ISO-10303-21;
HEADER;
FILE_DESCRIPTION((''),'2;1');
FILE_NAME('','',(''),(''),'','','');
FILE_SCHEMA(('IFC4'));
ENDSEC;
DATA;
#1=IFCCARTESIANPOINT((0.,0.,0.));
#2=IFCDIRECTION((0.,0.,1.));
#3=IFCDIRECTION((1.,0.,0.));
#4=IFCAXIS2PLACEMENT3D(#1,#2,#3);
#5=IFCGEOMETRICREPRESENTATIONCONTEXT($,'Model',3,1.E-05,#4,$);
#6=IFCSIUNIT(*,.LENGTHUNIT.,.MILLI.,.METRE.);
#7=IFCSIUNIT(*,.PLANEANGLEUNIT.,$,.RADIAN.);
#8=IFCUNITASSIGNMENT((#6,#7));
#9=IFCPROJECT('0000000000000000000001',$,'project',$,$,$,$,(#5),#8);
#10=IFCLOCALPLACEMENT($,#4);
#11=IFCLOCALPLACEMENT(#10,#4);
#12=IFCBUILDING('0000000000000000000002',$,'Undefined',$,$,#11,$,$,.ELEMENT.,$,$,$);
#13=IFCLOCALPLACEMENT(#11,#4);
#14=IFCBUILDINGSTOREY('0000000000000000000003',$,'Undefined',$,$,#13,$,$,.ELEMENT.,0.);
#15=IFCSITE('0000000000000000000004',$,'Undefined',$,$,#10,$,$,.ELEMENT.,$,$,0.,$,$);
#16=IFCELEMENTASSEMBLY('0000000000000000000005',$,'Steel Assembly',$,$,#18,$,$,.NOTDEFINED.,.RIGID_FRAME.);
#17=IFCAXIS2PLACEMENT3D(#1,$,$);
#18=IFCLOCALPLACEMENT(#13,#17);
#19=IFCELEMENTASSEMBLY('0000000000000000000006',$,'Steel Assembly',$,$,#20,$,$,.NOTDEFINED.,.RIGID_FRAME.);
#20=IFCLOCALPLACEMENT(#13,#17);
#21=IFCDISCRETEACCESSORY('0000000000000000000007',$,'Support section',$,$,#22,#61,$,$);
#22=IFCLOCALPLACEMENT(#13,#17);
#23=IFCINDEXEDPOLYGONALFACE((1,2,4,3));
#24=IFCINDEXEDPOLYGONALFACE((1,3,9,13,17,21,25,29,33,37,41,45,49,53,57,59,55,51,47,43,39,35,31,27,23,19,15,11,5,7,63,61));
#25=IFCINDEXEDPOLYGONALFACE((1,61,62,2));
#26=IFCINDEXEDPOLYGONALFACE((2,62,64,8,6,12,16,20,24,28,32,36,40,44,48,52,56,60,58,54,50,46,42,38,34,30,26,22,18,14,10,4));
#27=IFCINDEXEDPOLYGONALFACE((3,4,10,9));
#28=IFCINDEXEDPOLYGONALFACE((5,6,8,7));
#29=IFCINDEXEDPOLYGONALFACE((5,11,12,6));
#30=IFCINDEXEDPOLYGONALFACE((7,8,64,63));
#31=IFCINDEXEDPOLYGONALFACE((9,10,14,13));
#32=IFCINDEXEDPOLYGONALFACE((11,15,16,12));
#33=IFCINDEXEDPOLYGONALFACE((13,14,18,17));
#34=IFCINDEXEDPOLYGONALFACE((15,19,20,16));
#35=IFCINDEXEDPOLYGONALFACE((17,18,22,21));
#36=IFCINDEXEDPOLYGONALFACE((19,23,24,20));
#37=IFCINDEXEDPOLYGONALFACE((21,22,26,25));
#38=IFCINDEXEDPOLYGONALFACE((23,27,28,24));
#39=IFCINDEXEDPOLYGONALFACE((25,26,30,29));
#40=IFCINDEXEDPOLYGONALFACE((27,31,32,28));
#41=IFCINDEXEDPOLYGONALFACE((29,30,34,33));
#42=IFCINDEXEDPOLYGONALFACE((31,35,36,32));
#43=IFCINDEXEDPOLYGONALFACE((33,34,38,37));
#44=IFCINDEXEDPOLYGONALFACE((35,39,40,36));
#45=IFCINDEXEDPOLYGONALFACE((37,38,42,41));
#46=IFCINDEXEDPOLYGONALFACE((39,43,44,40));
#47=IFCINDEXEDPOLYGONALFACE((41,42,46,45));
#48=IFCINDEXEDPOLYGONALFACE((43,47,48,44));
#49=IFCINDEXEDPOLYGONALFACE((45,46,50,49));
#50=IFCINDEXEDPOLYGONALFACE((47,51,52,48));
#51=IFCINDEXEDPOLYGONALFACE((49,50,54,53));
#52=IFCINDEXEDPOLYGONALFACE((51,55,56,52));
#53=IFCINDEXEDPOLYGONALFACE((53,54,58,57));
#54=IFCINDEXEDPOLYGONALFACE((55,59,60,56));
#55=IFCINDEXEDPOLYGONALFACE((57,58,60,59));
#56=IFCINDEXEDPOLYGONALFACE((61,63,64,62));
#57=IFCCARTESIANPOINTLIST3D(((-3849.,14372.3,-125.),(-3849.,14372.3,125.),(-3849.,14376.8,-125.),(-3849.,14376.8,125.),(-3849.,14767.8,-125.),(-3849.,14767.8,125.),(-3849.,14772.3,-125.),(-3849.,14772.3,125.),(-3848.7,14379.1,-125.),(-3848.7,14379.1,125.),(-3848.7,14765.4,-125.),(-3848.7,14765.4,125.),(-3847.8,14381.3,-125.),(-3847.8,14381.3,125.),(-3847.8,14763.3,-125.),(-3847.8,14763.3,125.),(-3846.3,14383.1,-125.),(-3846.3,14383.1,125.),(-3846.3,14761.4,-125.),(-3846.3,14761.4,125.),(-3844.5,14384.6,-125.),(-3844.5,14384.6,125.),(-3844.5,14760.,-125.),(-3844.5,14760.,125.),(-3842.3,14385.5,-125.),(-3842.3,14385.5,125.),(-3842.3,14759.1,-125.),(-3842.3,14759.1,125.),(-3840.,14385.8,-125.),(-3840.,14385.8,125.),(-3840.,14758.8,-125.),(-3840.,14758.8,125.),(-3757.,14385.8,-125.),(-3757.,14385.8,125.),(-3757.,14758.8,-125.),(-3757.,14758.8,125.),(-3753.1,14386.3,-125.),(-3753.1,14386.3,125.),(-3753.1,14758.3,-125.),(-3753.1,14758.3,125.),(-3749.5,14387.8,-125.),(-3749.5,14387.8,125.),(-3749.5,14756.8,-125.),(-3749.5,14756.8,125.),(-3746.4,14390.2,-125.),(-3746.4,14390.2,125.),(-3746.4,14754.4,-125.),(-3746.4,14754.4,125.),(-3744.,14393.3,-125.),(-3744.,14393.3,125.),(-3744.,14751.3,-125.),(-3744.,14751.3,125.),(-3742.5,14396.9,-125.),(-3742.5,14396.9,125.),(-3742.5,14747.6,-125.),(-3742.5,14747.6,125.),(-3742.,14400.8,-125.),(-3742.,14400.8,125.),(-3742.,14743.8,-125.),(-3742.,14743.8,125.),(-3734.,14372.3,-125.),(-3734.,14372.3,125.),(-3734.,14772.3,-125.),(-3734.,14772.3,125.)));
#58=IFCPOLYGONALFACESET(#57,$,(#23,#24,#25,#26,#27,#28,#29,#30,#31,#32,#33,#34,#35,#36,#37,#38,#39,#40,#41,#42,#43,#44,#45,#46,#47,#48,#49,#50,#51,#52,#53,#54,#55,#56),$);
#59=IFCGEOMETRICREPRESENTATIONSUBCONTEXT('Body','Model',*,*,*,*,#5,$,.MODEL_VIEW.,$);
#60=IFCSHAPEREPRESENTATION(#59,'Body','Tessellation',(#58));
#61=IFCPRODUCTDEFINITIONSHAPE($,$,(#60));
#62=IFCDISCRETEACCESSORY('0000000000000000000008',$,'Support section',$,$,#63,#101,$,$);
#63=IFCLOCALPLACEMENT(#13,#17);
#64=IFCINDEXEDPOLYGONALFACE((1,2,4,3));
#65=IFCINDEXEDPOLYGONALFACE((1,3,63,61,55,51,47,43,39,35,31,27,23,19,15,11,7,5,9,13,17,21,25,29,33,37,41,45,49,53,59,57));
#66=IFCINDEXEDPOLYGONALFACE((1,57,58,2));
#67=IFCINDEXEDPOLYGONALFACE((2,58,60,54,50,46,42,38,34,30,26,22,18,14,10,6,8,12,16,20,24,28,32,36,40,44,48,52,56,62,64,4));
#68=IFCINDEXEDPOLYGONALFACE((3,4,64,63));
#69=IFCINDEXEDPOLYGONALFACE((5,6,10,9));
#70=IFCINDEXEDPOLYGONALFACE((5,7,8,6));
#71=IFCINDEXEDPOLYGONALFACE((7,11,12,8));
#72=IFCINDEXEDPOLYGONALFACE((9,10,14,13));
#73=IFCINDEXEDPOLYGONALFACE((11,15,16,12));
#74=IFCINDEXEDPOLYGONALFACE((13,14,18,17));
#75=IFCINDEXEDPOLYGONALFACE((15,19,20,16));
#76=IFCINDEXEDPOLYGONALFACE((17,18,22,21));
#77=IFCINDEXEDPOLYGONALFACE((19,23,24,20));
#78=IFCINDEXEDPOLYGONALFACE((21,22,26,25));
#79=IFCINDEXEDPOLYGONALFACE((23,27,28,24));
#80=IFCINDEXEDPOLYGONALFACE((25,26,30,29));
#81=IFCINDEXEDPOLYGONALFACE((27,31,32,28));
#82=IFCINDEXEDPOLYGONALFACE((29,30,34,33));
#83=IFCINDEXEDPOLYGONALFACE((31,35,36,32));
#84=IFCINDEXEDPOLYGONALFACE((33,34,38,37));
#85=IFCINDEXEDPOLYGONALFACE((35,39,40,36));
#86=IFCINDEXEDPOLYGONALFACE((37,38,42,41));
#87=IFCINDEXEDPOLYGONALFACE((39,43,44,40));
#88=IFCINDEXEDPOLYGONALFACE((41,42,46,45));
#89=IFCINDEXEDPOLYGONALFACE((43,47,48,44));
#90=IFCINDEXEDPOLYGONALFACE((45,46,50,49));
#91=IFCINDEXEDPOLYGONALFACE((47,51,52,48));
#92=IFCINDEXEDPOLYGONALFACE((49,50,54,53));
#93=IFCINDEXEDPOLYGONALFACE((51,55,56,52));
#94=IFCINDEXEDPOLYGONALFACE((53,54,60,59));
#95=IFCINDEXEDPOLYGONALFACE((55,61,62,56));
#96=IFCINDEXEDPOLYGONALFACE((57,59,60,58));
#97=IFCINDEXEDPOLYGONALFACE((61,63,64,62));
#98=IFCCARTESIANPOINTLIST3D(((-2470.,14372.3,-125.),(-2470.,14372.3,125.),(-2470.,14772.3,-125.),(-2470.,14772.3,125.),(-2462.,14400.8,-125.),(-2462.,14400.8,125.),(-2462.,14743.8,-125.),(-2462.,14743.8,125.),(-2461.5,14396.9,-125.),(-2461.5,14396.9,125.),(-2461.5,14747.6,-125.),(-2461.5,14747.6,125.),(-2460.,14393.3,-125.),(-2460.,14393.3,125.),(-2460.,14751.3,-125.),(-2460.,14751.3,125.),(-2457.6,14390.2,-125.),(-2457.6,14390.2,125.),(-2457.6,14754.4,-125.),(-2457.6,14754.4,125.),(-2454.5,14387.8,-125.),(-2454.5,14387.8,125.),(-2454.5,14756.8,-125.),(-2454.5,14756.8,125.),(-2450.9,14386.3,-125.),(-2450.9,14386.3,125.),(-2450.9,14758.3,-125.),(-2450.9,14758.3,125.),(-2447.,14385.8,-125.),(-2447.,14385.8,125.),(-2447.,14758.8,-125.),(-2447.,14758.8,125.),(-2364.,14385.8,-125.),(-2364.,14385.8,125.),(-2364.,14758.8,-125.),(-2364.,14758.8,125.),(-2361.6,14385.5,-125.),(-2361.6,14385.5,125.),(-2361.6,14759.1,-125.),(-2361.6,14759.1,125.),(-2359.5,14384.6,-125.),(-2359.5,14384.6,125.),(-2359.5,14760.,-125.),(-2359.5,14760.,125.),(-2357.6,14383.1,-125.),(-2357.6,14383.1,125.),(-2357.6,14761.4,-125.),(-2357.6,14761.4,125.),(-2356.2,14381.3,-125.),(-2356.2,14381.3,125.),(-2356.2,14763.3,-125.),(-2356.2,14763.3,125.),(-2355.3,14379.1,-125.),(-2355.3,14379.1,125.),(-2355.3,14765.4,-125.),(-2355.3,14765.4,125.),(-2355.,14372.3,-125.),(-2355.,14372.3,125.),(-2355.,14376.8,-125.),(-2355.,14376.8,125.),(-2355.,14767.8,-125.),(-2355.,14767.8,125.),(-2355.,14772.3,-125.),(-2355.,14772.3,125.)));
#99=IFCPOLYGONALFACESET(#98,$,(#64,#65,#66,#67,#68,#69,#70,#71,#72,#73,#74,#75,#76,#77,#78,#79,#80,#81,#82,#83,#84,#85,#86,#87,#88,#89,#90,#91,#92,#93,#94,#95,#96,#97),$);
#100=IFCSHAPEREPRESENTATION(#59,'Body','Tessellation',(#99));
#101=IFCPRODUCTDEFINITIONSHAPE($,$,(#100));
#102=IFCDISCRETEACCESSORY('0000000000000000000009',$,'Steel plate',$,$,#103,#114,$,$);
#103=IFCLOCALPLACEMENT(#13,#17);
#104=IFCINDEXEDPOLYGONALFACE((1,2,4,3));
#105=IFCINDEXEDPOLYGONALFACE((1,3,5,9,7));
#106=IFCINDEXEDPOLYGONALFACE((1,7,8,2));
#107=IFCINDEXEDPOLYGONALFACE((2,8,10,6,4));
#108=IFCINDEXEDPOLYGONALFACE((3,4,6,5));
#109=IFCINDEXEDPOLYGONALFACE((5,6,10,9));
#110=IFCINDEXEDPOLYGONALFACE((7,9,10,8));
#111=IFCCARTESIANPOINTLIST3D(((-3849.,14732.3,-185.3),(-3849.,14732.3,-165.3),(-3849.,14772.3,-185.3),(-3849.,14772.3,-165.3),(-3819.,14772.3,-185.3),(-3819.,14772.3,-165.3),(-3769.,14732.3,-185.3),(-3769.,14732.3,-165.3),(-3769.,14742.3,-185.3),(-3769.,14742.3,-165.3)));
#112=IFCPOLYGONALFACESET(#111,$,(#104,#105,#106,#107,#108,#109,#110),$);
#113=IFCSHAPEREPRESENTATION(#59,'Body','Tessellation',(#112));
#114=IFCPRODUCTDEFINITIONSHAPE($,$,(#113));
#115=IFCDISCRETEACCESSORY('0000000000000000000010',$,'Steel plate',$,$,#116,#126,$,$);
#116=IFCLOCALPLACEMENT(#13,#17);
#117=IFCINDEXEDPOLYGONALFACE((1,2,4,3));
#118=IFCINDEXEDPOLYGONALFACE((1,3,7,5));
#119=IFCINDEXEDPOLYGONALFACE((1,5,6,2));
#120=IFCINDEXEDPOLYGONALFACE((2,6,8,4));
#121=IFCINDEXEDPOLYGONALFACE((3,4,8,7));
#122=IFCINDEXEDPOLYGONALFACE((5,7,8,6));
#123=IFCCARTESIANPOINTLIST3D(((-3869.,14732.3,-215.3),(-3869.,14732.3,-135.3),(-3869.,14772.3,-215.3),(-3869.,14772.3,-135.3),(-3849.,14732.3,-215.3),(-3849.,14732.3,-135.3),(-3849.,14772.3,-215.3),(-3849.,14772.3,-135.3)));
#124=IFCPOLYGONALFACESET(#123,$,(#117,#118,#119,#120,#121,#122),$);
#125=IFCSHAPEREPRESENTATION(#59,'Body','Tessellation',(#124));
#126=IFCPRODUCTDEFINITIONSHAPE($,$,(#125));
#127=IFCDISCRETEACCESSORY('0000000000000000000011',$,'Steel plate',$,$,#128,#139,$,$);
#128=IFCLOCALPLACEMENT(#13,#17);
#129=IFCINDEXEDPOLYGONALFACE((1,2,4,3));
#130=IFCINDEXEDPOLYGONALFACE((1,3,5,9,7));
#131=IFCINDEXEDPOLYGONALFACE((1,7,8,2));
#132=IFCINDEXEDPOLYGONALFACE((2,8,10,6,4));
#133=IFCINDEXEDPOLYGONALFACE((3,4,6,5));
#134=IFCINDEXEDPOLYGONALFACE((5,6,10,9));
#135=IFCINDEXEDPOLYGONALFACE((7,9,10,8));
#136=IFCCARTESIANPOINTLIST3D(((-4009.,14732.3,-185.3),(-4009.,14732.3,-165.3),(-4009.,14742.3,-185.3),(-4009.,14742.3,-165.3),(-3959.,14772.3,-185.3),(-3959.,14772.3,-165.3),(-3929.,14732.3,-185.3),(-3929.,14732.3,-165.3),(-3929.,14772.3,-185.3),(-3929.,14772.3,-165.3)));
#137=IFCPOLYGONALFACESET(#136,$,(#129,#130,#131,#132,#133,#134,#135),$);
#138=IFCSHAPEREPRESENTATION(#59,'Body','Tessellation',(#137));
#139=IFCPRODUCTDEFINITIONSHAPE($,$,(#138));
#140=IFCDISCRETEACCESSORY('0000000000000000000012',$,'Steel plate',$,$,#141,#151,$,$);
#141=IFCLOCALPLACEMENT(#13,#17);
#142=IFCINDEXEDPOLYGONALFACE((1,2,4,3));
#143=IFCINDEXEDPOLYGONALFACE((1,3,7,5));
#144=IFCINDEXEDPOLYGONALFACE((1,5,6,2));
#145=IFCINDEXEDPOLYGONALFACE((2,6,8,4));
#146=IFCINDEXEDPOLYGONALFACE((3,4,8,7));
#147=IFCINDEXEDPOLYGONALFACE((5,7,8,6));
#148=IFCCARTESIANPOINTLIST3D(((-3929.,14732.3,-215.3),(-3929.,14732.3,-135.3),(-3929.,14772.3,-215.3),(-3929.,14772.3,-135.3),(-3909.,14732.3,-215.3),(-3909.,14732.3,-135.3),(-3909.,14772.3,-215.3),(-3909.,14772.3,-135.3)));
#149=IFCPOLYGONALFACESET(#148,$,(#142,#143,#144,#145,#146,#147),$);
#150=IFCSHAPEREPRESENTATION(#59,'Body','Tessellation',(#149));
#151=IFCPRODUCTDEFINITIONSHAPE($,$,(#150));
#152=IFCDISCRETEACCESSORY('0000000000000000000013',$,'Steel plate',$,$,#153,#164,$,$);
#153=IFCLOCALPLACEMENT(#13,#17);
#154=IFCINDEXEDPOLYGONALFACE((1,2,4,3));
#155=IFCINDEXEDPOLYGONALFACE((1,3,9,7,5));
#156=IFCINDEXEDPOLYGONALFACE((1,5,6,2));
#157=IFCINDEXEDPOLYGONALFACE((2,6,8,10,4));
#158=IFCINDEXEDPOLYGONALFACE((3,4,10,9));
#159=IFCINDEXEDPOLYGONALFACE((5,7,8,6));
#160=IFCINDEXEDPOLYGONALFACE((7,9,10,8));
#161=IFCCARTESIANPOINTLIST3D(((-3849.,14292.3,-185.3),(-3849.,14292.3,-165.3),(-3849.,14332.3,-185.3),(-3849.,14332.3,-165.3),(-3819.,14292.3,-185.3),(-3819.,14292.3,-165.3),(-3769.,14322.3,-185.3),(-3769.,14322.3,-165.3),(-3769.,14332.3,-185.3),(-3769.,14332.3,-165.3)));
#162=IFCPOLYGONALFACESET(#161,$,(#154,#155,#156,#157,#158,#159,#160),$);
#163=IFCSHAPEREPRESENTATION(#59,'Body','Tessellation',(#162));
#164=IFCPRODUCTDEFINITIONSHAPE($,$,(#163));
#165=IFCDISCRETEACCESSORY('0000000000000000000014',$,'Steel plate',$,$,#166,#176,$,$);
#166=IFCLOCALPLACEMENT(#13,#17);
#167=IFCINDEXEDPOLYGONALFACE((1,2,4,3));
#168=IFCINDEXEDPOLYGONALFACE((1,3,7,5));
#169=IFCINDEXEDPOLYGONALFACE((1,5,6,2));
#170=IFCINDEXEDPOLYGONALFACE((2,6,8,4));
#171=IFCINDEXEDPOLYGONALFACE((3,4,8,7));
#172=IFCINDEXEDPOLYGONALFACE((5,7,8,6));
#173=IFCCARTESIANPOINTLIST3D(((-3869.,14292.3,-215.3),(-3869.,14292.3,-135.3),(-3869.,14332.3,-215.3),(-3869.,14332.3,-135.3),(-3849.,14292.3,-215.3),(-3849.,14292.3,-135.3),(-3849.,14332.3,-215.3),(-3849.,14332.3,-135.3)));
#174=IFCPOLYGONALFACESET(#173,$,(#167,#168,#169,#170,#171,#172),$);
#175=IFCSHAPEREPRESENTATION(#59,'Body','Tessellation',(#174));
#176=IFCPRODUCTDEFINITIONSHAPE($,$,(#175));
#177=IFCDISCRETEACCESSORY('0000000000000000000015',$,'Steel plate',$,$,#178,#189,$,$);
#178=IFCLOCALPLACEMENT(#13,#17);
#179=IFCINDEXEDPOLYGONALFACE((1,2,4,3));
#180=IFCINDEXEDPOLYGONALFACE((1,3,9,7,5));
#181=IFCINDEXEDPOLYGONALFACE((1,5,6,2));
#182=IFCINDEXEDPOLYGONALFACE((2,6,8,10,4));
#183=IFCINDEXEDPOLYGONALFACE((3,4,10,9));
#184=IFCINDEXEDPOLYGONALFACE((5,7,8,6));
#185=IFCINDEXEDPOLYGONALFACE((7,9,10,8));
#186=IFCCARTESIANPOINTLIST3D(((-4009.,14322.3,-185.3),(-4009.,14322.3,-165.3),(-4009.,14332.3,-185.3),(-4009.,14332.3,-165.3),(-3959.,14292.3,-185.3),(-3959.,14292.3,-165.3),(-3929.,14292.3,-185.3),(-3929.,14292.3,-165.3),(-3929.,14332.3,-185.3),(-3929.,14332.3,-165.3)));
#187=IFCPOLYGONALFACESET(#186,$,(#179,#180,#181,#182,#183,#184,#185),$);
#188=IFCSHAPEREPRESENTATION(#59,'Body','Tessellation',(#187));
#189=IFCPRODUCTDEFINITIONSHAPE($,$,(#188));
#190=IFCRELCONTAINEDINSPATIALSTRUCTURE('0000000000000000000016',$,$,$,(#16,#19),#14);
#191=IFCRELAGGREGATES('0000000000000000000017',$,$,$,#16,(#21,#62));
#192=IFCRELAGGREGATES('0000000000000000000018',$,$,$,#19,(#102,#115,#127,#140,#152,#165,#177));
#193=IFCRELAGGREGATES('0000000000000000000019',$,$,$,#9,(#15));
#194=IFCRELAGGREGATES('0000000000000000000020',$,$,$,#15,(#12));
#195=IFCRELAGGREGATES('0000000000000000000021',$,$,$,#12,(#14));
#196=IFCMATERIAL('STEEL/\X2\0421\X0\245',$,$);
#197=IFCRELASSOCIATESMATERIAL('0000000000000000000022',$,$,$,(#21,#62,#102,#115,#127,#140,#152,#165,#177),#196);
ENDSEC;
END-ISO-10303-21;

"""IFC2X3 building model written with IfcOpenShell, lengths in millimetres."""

from ifc_helpers import new_model, si_unit, frame, origin_with_axes, origin_2d_with_axis, place, context, subcontext, project, spatial, polyline, u_section, outline, extrude, material, element, aggregate, save


model = new_model("IFC2X3")

# Units and contexts
model_context = context("Model", 3, precision=1e-05, world=origin_with_axes())
body_context = subcontext(model_context, "Body", "Model", "MODEL_VIEW")
ifc_project = project(units=[si_unit("LENGTHUNIT", "METRE", prefix="MILLI"), si_unit("PLANEANGLEUNIT", "RADIAN")], contexts=[model_context])

# Site, building, storey
site_placement = place(None, origin_with_axes())
site = spatial("IfcSite", under=ifc_project, at=site_placement, Name="Undefined", CompositionType="ELEMENT", RefElevation=0.0)
building_placement = place(site_placement, origin_with_axes())
building = spatial("IfcBuilding", under=site, at=building_placement, Name="Undefined", CompositionType="ELEMENT")
storey_placement = place(building_placement, origin_with_axes())
storey = spatial("IfcBuildingStorey", under=building, at=storey_placement, Name="Undefined", CompositionType="ELEMENT", Elevation=0.0)

# Element assembly
assembly_1_placement = place(storey_placement, origin_with_axes())
assembly_1 = element("IfcElementAssembly", 1, at=assembly_1_placement, inside=storey, Name="Steel Assembly", AssemblyPlace="NOTDEFINED", PredefinedType="RIGID_FRAME")
ifc_material = material(Name="STEEL/С245")

# Element assembly
assembly_2_placement = place(storey_placement, origin_with_axes())
assembly_2 = element("IfcElementAssembly", 2, at=assembly_2_placement, inside=storey, Name="Steel Assembly", AssemblyPlace="NOTDEFINED", PredefinedType="RIGID_FRAME")

# Discrete accessories
discrete_accessory_1_placement = place(assembly_1_placement, frame((-3791.5, 14572.3, -125.0), z_axis=(0.0, 0.0, 1.0), x_axis=(1.0, 0.0, 0.0)))
discrete_accessory_1 = element("IfcDiscreteAccessory", 3, at=discrete_accessory_1_placement, material=ifc_material, Name="Support section", context=body_context, shape_type="SweptSolid", body=[
    extrude(u_section(Depth=400.0, FlangeWidth=115.0, WebThickness=8.0, FlangeThickness=13.5, FilletRadius=15.0, EdgeRadius=9.0, at=origin_2d_with_axis()), frame((0.0, 0.0, 250.0), z_axis=(0.0, 0.0, -1.0), x_axis=(-1.0, 0.0, 0.0)), (0.0, 0.0, 1.0), 250.0),
])
discrete_accessory_2_placement = place(assembly_1_placement, frame((-2412.5, 14572.3, 125.0), z_axis=(0.0, 1.0, 0.0), x_axis=(0.0, 0.0, -1.0)))
discrete_accessory_2 = element("IfcDiscreteAccessory", 4, at=discrete_accessory_2_placement, material=ifc_material, Name="Support section", context=body_context, shape_type="SweptSolid", body=[
    extrude(u_section(Depth=400.0, FlangeWidth=115.0, WebThickness=8.0, FlangeThickness=13.5, FilletRadius=15.0, EdgeRadius=9.0, at=origin_2d_with_axis()), frame((250.0, 0.0, 0.0), z_axis=(-1.0, 0.0, 0.0), x_axis=(0.0, -1.0, 0.0)), (0.0, 0.0, 1.0), 250.0),
])
aggregate(assembly_1, [discrete_accessory_1, discrete_accessory_2])
discrete_accessory_3_placement = place(assembly_2_placement, frame((-3849.0, 14732.3, -175.3), z_axis=(0.000002, 0.0, 1.0), x_axis=(1.0, 0.0, -0.000002)))
discrete_accessory_3 = element("IfcDiscreteAccessory", 5, at=discrete_accessory_3_placement, material=ifc_material, Name="Steel plate", context=body_context, shape_type="SweptSolid", body=[
    extrude(outline(polyline([(0.0, 0.0), (80.0, 0.0), (80.0, 10.0), (30.0, 40.0), (0.0, 40.0), (0.0, 0.0)])), frame((0.0, 0.0, -10.0), z_axis=(0.0, 0.0, 1.0), x_axis=(1.0, 0.0, 0.0)), (0.0, 0.0, 1.0), 20.0),
])
discrete_accessory_4_placement = place(assembly_2_placement, frame((-3859.0, 14732.3, -215.3), z_axis=(-1.0, 0.0, 0.0), x_axis=(0.0, 0.0, 1.0)))
discrete_accessory_4 = element("IfcDiscreteAccessory", 6, at=discrete_accessory_4_placement, material=ifc_material, Name="Steel plate", context=body_context, shape_type="SweptSolid", body=[
    extrude(outline(polyline([(0.0, 0.0), (80.0, 0.0), (80.0, 40.0), (0.0, 40.0), (0.0, 0.0)])), frame((0.0, 0.0, -10.0), z_axis=(0.0, 0.0, 1.0), x_axis=(1.0, 0.0, 0.0)), (0.0, 0.0, 1.0), 20.0),
])
discrete_accessory_5_placement = place(assembly_2_placement, frame((-3929.0, 14732.3, -175.3), z_axis=(0.000002, 0.0, -1.0), x_axis=(-1.0, 0.0, -0.000002)))
discrete_accessory_5 = element("IfcDiscreteAccessory", 7, at=discrete_accessory_5_placement, material=ifc_material, Name="Steel plate", context=body_context, shape_type="SweptSolid", body=[
    extrude(outline(polyline([(0.0, 0.0), (80.0, 0.0), (80.0, 10.0), (30.0, 40.0), (0.0, 40.0), (0.0, 0.0)])), frame((0.0, 0.0, -10.0), z_axis=(0.0, 0.0, 1.0), x_axis=(1.0, 0.0, 0.0)), (0.0, 0.0, 1.0), 20.0),
])
discrete_accessory_6_placement = place(assembly_2_placement, frame((-3919.0, 14732.3, -215.3), z_axis=(-1.0, 0.0, 0.0), x_axis=(0.0, 0.0, 1.0)))
discrete_accessory_6 = element("IfcDiscreteAccessory", 8, at=discrete_accessory_6_placement, material=ifc_material, Name="Steel plate", context=body_context, shape_type="SweptSolid", body=[
    extrude(outline(polyline([(0.0, 0.0), (80.0, 0.0), (80.0, 40.0), (0.0, 40.0), (0.0, 0.0)])), frame((0.0, 0.0, -10.0), z_axis=(0.0, 0.0, 1.0), x_axis=(1.0, 0.0, 0.0)), (0.0, 0.0, 1.0), 20.0),
])
discrete_accessory_7_placement = place(assembly_2_placement, frame((-3849.0, 14332.3, -175.3), z_axis=(-0.000002, 0.0, -1.0), x_axis=(1.0, 0.0, -0.000002)))
discrete_accessory_7 = element("IfcDiscreteAccessory", 9, at=discrete_accessory_7_placement, material=ifc_material, Name="Steel plate", context=body_context, shape_type="SweptSolid", body=[
    extrude(outline(polyline([(0.0, 0.0), (80.0, 0.0), (80.0, 10.0), (30.0, 40.0), (0.0, 40.0), (0.0, 0.0)])), frame((0.0, 0.0, -10.0), z_axis=(0.0, 0.0, 1.0), x_axis=(1.0, 0.0, 0.0)), (0.0, 0.0, 1.0), 20.0),
])
discrete_accessory_8_placement = place(assembly_2_placement, frame((-3859.0, 14332.3, -215.3), z_axis=(1.0, 0.0, 0.0), x_axis=(0.0, 0.0, 1.0)))
discrete_accessory_8 = element("IfcDiscreteAccessory", 10, at=discrete_accessory_8_placement, material=ifc_material, Name="Steel plate", context=body_context, shape_type="SweptSolid", body=[
    extrude(outline(polyline([(0.0, 0.0), (80.0, 0.0), (80.0, 40.0), (0.0, 40.0), (0.0, 0.0)])), frame((0.0, 0.0, -10.0), z_axis=(0.0, 0.0, 1.0), x_axis=(1.0, 0.0, 0.0)), (0.0, 0.0, 1.0), 20.0),
])
discrete_accessory_9_placement = place(assembly_2_placement, frame((-3929.0, 14332.3, -175.3), z_axis=(-0.000002, 0.0, 1.0), x_axis=(-1.0, 0.0, -0.000002)))
discrete_accessory_9 = element("IfcDiscreteAccessory", 11, at=discrete_accessory_9_placement, material=ifc_material, Name="Steel plate", context=body_context, shape_type="SweptSolid", body=[
    extrude(outline(polyline([(0.0, 0.0), (80.0, 0.0), (80.0, 10.0), (30.0, 40.0), (0.0, 40.0), (0.0, 0.0)])), frame((0.0, 0.0, -10.0), z_axis=(0.0, 0.0, 1.0), x_axis=(1.0, 0.0, 0.0)), (0.0, 0.0, 1.0), 20.0),
])
aggregate(assembly_2, [discrete_accessory_3, discrete_accessory_4, discrete_accessory_5, discrete_accessory_6, discrete_accessory_7, discrete_accessory_8, discrete_accessory_9])

save(model, "model.ifc")
